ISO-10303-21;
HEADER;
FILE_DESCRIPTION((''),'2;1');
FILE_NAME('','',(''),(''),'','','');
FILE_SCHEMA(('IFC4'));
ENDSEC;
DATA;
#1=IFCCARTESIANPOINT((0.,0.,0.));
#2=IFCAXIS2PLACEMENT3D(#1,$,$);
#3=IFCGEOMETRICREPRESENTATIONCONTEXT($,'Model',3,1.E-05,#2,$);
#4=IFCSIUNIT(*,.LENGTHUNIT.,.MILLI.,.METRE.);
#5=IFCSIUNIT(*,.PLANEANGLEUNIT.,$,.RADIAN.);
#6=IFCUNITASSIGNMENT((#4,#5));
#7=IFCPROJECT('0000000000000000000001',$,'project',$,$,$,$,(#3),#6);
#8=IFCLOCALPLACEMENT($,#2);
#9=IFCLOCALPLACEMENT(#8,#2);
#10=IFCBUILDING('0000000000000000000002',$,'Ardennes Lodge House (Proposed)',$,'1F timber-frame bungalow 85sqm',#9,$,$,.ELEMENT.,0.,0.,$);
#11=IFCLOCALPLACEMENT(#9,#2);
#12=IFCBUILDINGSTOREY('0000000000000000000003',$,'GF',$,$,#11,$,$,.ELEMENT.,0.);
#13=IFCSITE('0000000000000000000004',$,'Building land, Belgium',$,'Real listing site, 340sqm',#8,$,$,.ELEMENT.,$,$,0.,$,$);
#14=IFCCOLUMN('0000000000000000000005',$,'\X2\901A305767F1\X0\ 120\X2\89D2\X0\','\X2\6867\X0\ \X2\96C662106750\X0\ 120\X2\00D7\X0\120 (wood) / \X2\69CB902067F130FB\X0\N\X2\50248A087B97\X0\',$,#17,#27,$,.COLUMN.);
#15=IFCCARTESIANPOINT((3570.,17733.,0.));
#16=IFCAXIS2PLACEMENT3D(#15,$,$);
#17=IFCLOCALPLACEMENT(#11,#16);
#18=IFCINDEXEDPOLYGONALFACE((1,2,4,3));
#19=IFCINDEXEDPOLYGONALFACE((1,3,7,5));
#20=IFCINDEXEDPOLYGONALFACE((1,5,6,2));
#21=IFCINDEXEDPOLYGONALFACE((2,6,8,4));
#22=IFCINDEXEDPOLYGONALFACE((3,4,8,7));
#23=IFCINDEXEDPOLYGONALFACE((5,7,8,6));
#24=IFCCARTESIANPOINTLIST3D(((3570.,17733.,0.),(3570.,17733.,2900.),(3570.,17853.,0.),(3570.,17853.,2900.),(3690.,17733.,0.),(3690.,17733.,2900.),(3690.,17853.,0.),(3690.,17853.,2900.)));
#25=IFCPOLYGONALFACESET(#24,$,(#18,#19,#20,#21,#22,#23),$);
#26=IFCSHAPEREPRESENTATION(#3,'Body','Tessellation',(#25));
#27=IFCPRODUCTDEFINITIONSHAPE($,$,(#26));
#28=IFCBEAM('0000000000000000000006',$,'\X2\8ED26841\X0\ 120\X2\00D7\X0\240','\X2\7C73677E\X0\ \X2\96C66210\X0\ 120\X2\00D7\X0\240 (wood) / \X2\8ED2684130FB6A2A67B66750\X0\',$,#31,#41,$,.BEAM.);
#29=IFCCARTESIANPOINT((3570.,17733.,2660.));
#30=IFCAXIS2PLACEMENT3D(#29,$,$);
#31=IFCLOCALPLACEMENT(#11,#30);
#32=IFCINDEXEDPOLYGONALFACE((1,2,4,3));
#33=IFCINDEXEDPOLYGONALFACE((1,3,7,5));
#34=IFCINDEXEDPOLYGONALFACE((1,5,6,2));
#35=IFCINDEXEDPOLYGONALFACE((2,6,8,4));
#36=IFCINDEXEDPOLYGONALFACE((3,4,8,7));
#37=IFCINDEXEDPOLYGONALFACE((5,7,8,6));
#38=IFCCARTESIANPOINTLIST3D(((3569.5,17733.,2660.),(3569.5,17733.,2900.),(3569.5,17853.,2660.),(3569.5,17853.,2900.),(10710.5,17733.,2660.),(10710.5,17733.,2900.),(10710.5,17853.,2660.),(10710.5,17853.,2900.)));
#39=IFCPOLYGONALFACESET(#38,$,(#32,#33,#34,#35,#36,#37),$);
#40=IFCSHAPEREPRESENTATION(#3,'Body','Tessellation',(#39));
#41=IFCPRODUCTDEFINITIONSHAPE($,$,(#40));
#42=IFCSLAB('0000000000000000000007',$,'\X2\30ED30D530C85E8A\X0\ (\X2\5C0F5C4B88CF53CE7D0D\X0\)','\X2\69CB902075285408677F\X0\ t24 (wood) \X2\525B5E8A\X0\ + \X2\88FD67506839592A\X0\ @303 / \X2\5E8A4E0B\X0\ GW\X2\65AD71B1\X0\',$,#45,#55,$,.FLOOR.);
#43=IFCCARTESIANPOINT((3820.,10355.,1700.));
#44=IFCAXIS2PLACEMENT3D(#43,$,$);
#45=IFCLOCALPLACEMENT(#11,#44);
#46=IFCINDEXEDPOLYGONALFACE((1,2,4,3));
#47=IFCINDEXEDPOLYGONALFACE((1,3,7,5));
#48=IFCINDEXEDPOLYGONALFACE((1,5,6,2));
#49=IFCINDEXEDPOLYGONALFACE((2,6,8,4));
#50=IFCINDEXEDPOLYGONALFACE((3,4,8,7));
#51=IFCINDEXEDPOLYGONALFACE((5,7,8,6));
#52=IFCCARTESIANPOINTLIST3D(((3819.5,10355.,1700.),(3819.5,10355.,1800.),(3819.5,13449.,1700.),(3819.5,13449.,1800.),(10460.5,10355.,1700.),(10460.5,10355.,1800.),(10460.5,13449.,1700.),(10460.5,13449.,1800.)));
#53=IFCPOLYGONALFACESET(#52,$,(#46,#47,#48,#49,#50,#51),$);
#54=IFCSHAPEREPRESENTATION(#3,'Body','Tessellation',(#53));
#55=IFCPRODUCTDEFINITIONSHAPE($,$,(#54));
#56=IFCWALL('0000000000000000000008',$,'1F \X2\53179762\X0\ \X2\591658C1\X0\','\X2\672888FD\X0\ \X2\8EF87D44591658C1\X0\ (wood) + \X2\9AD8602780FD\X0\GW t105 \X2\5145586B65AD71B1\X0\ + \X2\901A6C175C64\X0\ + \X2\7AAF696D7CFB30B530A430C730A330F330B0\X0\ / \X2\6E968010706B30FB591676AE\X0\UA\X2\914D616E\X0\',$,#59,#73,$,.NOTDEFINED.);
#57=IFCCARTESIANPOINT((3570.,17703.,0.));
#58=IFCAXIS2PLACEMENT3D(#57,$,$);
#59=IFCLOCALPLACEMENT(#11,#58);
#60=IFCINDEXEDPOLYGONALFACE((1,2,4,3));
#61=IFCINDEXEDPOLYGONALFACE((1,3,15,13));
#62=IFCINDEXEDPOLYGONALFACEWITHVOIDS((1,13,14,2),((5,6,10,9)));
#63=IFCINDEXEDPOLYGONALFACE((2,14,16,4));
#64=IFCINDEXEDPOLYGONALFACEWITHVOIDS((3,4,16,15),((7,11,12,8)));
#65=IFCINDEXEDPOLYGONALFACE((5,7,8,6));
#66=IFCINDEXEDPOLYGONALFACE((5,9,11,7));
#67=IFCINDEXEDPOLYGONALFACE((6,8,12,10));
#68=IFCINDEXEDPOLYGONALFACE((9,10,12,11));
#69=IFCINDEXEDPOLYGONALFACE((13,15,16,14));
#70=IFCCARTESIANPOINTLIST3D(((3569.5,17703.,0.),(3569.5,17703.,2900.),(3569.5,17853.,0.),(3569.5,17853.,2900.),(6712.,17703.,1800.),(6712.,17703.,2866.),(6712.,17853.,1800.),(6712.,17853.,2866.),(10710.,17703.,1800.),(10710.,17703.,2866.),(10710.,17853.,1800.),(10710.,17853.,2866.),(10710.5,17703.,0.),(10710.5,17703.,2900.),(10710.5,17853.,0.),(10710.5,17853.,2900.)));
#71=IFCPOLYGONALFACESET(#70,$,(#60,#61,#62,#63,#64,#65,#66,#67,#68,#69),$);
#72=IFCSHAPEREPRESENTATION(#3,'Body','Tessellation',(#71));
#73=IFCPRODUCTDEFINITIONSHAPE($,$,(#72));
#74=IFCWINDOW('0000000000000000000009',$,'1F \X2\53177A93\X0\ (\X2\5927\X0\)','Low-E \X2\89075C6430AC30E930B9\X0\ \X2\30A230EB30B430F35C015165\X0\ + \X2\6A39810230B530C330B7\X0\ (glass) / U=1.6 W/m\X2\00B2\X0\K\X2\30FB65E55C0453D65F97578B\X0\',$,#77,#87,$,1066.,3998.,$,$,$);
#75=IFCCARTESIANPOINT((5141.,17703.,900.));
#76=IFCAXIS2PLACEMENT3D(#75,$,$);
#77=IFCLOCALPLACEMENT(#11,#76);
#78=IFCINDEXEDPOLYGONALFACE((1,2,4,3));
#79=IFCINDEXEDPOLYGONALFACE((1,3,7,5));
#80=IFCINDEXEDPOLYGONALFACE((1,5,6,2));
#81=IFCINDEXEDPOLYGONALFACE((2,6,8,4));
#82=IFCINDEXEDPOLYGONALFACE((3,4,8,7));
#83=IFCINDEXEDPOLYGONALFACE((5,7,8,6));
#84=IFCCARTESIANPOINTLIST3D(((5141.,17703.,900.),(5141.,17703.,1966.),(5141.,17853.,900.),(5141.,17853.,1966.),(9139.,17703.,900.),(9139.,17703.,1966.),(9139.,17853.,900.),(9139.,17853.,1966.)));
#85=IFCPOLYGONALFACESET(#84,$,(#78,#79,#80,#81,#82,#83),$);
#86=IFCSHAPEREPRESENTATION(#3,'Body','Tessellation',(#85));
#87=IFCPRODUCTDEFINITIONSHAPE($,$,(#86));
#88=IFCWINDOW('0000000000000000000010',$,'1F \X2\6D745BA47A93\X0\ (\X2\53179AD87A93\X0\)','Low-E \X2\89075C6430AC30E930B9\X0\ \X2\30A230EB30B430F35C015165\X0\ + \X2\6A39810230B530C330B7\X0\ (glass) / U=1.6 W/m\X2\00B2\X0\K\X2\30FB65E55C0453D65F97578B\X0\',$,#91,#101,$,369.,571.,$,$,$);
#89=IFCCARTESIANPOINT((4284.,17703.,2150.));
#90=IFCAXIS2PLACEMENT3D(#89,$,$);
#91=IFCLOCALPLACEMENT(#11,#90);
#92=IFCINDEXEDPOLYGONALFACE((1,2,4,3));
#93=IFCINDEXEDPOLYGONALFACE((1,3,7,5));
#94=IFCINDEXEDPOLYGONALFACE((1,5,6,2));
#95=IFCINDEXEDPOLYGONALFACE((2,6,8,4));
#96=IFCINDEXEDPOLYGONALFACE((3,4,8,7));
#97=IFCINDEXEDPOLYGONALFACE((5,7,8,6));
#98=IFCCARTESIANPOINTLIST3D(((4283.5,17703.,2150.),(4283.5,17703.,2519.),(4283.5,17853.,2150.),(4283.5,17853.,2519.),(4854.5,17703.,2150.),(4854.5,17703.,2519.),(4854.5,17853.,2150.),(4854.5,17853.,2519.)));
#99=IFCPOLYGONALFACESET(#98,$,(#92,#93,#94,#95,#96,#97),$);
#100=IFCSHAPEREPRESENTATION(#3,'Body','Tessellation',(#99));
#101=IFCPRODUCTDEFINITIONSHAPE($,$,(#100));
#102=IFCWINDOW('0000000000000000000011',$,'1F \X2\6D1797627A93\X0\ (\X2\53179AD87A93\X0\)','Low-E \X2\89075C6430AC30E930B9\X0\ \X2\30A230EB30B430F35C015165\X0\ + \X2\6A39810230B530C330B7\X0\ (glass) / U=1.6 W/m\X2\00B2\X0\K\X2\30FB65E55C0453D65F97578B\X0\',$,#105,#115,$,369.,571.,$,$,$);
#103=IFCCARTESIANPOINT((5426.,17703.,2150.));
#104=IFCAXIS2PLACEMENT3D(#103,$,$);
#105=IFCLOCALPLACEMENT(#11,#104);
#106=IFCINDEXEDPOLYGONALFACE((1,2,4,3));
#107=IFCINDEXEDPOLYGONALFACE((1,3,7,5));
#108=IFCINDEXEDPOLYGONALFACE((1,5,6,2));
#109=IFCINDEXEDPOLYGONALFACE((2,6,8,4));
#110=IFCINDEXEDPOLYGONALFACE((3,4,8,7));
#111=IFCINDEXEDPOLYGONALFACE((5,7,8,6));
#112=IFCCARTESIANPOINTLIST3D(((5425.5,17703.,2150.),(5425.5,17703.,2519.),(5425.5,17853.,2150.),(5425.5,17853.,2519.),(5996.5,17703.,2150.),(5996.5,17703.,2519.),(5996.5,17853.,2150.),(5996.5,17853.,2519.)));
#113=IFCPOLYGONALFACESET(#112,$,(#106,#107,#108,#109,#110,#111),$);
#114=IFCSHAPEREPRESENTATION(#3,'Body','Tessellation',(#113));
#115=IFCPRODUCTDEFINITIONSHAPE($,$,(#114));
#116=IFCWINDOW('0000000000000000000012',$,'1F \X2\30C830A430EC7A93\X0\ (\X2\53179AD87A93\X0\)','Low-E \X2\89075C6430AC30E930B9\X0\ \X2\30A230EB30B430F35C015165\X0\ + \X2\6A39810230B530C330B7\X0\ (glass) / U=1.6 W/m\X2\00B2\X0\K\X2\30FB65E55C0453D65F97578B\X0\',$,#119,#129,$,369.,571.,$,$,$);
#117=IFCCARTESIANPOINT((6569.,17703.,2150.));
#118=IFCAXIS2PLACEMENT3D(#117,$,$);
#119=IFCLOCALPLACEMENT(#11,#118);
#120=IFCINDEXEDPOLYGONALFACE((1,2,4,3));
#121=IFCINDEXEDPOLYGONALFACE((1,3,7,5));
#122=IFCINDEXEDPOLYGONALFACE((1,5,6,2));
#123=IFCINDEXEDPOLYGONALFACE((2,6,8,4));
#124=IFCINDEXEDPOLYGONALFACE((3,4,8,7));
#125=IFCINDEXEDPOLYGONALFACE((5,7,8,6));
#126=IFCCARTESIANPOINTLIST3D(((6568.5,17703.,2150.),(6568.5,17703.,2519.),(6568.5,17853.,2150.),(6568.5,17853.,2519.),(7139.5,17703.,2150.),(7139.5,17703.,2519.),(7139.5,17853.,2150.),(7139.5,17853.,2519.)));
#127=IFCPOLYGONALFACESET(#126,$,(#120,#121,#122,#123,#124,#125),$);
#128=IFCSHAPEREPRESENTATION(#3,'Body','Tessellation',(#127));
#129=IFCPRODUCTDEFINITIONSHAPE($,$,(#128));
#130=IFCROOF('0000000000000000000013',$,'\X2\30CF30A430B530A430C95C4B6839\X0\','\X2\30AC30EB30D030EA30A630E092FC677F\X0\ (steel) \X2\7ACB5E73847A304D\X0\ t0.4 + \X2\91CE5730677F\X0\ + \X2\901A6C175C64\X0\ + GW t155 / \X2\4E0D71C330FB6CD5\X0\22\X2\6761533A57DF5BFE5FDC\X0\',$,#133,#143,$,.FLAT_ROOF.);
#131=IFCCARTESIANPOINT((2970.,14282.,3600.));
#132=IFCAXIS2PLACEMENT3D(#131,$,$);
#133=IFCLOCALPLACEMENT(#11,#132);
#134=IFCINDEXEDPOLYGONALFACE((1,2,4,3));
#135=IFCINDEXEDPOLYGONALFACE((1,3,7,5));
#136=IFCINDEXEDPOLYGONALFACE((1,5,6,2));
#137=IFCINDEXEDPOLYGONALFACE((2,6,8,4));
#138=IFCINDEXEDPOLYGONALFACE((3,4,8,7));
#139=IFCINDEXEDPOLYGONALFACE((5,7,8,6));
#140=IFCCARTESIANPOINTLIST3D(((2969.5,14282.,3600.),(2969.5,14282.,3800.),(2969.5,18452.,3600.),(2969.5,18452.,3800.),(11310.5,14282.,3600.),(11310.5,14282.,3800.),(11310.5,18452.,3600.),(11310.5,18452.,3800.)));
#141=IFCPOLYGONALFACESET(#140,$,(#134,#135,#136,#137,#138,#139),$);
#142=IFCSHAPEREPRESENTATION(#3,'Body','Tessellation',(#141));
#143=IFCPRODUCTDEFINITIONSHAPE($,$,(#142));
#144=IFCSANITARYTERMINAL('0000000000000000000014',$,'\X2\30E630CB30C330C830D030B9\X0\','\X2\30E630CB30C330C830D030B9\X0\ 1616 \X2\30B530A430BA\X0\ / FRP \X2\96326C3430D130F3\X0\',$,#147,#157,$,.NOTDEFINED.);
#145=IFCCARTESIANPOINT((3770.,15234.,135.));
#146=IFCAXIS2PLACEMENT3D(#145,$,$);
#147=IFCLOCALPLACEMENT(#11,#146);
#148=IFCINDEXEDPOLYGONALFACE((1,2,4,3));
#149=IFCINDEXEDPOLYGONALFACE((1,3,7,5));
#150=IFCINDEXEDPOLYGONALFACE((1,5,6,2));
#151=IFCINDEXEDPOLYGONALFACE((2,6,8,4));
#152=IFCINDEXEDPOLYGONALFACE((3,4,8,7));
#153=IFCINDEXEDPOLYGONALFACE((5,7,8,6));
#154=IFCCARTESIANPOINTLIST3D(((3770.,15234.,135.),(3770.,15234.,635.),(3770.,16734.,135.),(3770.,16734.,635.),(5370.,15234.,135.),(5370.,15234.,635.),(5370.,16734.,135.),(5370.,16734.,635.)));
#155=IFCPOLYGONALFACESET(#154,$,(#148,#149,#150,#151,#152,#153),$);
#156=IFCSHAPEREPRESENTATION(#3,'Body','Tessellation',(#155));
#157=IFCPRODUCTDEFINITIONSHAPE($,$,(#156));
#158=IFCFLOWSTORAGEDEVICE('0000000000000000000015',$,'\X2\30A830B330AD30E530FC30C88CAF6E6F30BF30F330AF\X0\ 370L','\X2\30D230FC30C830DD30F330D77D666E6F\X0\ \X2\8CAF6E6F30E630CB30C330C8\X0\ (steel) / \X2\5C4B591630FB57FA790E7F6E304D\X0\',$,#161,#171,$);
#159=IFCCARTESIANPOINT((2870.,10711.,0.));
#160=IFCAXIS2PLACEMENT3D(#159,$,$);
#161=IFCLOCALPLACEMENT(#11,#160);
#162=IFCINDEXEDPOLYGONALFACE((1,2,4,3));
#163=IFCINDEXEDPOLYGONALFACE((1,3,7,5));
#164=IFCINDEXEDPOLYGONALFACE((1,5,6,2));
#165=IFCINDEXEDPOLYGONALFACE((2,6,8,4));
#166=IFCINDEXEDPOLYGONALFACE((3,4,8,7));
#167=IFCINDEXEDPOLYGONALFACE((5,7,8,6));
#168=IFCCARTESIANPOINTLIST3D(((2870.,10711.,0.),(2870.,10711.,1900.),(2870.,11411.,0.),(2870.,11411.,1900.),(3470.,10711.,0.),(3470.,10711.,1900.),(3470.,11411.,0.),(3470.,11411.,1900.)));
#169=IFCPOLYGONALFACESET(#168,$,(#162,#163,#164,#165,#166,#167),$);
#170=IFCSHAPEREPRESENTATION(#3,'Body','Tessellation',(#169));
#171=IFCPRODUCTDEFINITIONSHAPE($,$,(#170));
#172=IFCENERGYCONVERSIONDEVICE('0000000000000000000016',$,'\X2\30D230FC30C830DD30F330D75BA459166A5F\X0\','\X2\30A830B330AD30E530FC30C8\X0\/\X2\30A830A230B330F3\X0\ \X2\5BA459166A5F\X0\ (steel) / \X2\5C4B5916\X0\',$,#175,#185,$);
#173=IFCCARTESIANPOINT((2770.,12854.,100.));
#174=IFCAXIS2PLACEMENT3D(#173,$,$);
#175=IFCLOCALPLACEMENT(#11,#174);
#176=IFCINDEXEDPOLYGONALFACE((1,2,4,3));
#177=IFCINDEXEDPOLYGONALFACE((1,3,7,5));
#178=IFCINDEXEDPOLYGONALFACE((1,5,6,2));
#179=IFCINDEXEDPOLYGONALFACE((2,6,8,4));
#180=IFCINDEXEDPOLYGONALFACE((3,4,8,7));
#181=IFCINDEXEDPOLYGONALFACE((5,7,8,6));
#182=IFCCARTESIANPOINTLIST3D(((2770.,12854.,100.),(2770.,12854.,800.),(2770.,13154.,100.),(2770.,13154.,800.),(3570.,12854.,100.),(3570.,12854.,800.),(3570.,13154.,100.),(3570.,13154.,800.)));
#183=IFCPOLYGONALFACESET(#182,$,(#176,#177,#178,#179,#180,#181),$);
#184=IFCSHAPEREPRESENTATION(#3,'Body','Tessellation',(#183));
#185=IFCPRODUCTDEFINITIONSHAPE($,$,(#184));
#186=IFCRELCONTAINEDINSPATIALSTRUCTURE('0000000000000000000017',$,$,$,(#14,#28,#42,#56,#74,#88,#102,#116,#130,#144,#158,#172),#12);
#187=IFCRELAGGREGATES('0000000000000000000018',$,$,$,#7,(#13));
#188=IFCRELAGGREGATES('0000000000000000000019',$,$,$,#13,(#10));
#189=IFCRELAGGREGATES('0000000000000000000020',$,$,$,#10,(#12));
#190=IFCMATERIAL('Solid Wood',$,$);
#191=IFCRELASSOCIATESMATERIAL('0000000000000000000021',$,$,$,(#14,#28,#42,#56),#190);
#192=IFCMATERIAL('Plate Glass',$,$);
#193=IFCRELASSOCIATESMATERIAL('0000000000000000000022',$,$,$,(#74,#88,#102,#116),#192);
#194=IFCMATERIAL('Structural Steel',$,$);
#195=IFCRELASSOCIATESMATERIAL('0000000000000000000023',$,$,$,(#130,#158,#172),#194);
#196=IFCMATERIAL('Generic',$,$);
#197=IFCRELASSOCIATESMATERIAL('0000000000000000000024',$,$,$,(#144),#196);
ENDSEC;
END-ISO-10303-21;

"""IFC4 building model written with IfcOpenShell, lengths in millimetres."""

from ifc_helpers import new_model, si_unit, frame, frame_2d, origin, place, context, project, spatial, rectangle, extrude, material, element, fill, save


model = new_model("IFC4")

# Units and contexts
model_context = context("Model", 3, precision=1e-05, world=origin())
ifc_project = project(units=[si_unit("LENGTHUNIT", "METRE", prefix="MILLI"), si_unit("PLANEANGLEUNIT", "RADIAN")], contexts=[model_context])

# Site, building, storey
site_placement = place(None, origin())
site = spatial("IfcSite", under=ifc_project, at=site_placement, Name="Building land, Belgium", ObjectType="Real listing site, 340sqm", CompositionType="ELEMENT", RefElevation=0.0)
building_placement = place(site_placement, origin())
building = spatial("IfcBuilding", under=site, at=building_placement, Name="Ardennes Lodge House (Proposed)", ObjectType="1F timber-frame bungalow 85sqm", CompositionType="ELEMENT", ElevationOfRefHeight=0.0, ElevationOfTerrain=0.0)
storey_placement = place(building_placement, origin())
storey = spatial("IfcBuildingStorey", under=building, at=storey_placement, Name="GF", CompositionType="ELEMENT", Elevation=0.0)

# Column
ifc_material_1 = material(Name="Solid Wood")
column_1_placement = place(storey_placement, frame((3570.0, 17733.0, 0.0)))
element("IfcColumn", 1, at=column_1_placement, inside=storey, material=ifc_material_1, Name="通し柱 120角", Description="桧 集成材 120×120 (wood) / 構造柱・N値計算", PredefinedType="COLUMN", context=model_context, shape_type="SweptSolid", body=[
    extrude(rectangle(XDim=120.0, YDim=120.0, at=frame_2d((60.0, 60.0))), frame((3570.0, 17733.0, 0.0)), (0.0, 0.0, 1.0), 2900.0),
])

# Beam
beam_1_placement = place(storey_placement, frame((3570.0, 17733.0, 2660.0)))
element("IfcBeam", 2, at=beam_1_placement, inside=storey, material=ifc_material_1, Name="軒桁 120×240", Description="米松 集成 120×240 (wood) / 軒桁・横架材", PredefinedType="BEAM", context=model_context, shape_type="SweptSolid", body=[
    extrude(rectangle(XDim=7141.0, YDim=120.0, at=frame_2d((3570.0, 60.0))), frame((3570.0, 17733.0, 2660.0)), (0.0, 0.0, 1.0), 240.0),
])

# Slab
slab_placement = place(storey_placement, frame((3820.0, 10355.0, 1700.0)))
element("IfcSlab", 3, at=slab_placement, inside=storey, material=ifc_material_1, Name="ロフト床 (小屋裏収納)", Description="構造用合板 t24 (wood) 剛床 + 製材根太 @303 / 床下 GW断熱", PredefinedType="FLOOR", context=model_context, shape_type="SweptSolid", body=[
    extrude(rectangle(XDim=6641.0, YDim=3094.0, at=frame_2d((3320.0, 1547.0))), frame((3820.0, 10355.0, 1700.0)), (0.0, 0.0, 1.0), 100.0),
])

# Wall, openings, windows
wall_1_placement = place(storey_placement, frame((3570.0, 17703.0, 0.0)))
wall_1 = element("IfcWall", 4, at=wall_1_placement, inside=storey, material=ifc_material_1, Name="1F 北面 外壁", Description="木製 軸組外壁 (wood) + 高性能GW t105 充填断熱 + 通気層 + 窯業系サイディング / 準耐火・外皮UA配慮", PredefinedType="NOTDEFINED", context=model_context, shape_type="SweptSolid", body=[
    extrude(rectangle(XDim=7141.0, YDim=150.0, at=frame_2d((3570.0, 75.0))), frame((3570.0, 17703.0, 0.0)), (0.0, 0.0, 1.0), 2900.0),
])
opening_1_placement = place(storey_placement, frame((5141.0, 17703.0, 900.0)))
opening_1 = element("IfcOpeningElement", 5, at=opening_1_placement, cuts=wall_1, PredefinedType="NOTDEFINED", context=model_context, shape_type="SweptSolid", body=[
    extrude(rectangle(XDim=3998.0, YDim=150.0, at=frame_2d((1999.0, 75.0))), frame((5141.0, 17703.0, 900.0)), (0.0, 0.0, 1.0), 1066.0),
])
opening_2_placement = place(storey_placement, frame((4284.0, 17703.0, 2150.0)))
opening_2 = element("IfcOpeningElement", 6, at=opening_2_placement, cuts=wall_1, PredefinedType="NOTDEFINED", context=model_context, shape_type="SweptSolid", body=[
    extrude(rectangle(XDim=571.0, YDim=150.0, at=frame_2d((285.0, 75.0))), frame((4284.0, 17703.0, 2150.0)), (0.0, 0.0, 1.0), 369.0),
])
opening_3_placement = place(storey_placement, frame((5426.0, 17703.0, 2150.0)))
opening_3 = element("IfcOpeningElement", 7, at=opening_3_placement, cuts=wall_1, PredefinedType="NOTDEFINED", context=model_context, shape_type="SweptSolid", body=[
    extrude(rectangle(XDim=571.0, YDim=150.0, at=frame_2d((285.0, 75.0))), frame((5426.0, 17703.0, 2150.0)), (0.0, 0.0, 1.0), 369.0),
])
opening_4_placement = place(storey_placement, frame((6569.0, 17703.0, 2150.0)))
opening_4 = element("IfcOpeningElement", 8, at=opening_4_placement, cuts=wall_1, PredefinedType="NOTDEFINED", context=model_context, shape_type="SweptSolid", body=[
    extrude(rectangle(XDim=571.0, YDim=150.0, at=frame_2d((285.0, 75.0))), frame((6569.0, 17703.0, 2150.0)), (0.0, 0.0, 1.0), 369.0),
])
ifc_material_2 = material(Name="Plate Glass")
window_1_placement = place(storey_placement, frame((5141.0, 17703.0, 900.0)))
window_1 = element("IfcWindow", 9, at=window_1_placement, inside=storey, material=ifc_material_2, Name="1F 北窓 (大)", Description="Low-E 複層ガラス アルゴン封入 + 樹脂サッシ (glass) / U=1.6 W/m²K・日射取得型", OverallHeight=1066.0, OverallWidth=3998.0, context=model_context, shape_type="SweptSolid", body=[
    extrude(rectangle(XDim=3998.0, YDim=150.0, at=frame_2d((1999.0, 75.0))), frame((5141.0, 17703.0, 900.0)), (0.0, 0.0, 1.0), 1066.0),
])
fill(opening_1, window_1)
window_2_placement = place(storey_placement, frame((4284.0, 17703.0, 2150.0)))
window_2 = element("IfcWindow", 10, at=window_2_placement, inside=storey, material=ifc_material_2, Name="1F 浴室窓 (北高窓)", Description="Low-E 複層ガラス アルゴン封入 + 樹脂サッシ (glass) / U=1.6 W/m²K・日射取得型", OverallHeight=369.0, OverallWidth=571.0, context=model_context, shape_type="SweptSolid", body=[
    extrude(rectangle(XDim=571.0, YDim=150.0, at=frame_2d((285.0, 75.0))), frame((4284.0, 17703.0, 2150.0)), (0.0, 0.0, 1.0), 369.0),
])
fill(opening_2, window_2)
window_3_placement = place(storey_placement, frame((5426.0, 17703.0, 2150.0)))
window_3 = element("IfcWindow", 11, at=window_3_placement, inside=storey, material=ifc_material_2, Name="1F 洗面窓 (北高窓)", Description="Low-E 複層ガラス アルゴン封入 + 樹脂サッシ (glass) / U=1.6 W/m²K・日射取得型", OverallHeight=369.0, OverallWidth=571.0, context=model_context, shape_type="SweptSolid", body=[
    extrude(rectangle(XDim=571.0, YDim=150.0, at=frame_2d((285.0, 75.0))), frame((5426.0, 17703.0, 2150.0)), (0.0, 0.0, 1.0), 369.0),
])
fill(opening_3, window_3)
window_4_placement = place(storey_placement, frame((6569.0, 17703.0, 2150.0)))
window_4 = element("IfcWindow", 12, at=window_4_placement, inside=storey, material=ifc_material_2, Name="1F トイレ窓 (北高窓)", Description="Low-E 複層ガラス アルゴン封入 + 樹脂サッシ (glass) / U=1.6 W/m²K・日射取得型", OverallHeight=369.0, OverallWidth=571.0, context=model_context, shape_type="SweptSolid", body=[
    extrude(rectangle(XDim=571.0, YDim=150.0, at=frame_2d((285.0, 75.0))), frame((6569.0, 17703.0, 2150.0)), (0.0, 0.0, 1.0), 369.0),
])
fill(opening_4, window_4)

# Roof
ifc_material_3 = material(Name="Structural Steel")
roof_placement = place(storey_placement, frame((2970.0, 14282.0, 3600.0)))
element("IfcRoof", 13, at=roof_placement, inside=storey, material=ifc_material_3, Name="ハイサイド屋根", Description="ガルバリウム鋼板 (steel) 立平葺き t0.4 + 野地板 + 通気層 + GW t155 / 不燃・法22条区域対応", PredefinedType="FLAT_ROOF", context=model_context, shape_type="SweptSolid", body=[
    extrude(rectangle(XDim=8341.0, YDim=4170.0, at=frame_2d((4170.0, 2085.0))), frame((2970.0, 14282.0, 3600.0)), (0.0, 0.0, 1.0), 200.0),
])

# Sanitary terminal
ifc_material_4 = material(Name="Generic")
sanitary_terminal_placement = place(storey_placement, frame((3770.0, 15234.0, 135.0)))
element("IfcSanitaryTerminal", 14, at=sanitary_terminal_placement, inside=storey, material=ifc_material_4, Name="ユニットバス", Description="ユニットバス 1616 サイズ / FRP 防水パン", PredefinedType="NOTDEFINED", context=model_context, shape_type="SweptSolid", body=[
    extrude(rectangle(XDim=1600.0, YDim=1500.0, at=frame_2d((800.0, 750.0))), frame((3770.0, 15234.0, 135.0)), (0.0, 0.0, 1.0), 500.0),
])

# Flow storage device
flow_storage_device_placement = place(storey_placement, frame((2870.0, 10711.0, 0.0)))
element("IfcFlowStorageDevice", 15, at=flow_storage_device_placement, inside=storey, material=ifc_material_3, Name="エコキュート貯湯タンク 370L", Description="ヒートポンプ給湯 貯湯ユニット (steel) / 屋外・基礎置き", context=model_context, shape_type="SweptSolid", body=[
    extrude(rectangle(XDim=600.0, YDim=700.0, at=frame_2d((300.0, 350.0))), frame((2870.0, 10711.0, 0.0)), (0.0, 0.0, 1.0), 1900.0),
])

# Energy conversion device
energy_conversion_device_placement = place(storey_placement, frame((2770.0, 12854.0, 100.0)))
element("IfcEnergyConversionDevice", 16, at=energy_conversion_device_placement, inside=storey, material=ifc_material_3, Name="ヒートポンプ室外機", Description="エコキュート/エアコン 室外機 (steel) / 屋外", context=model_context, shape_type="SweptSolid", body=[
    extrude(rectangle(XDim=800.0, YDim=300.0, at=frame_2d((400.0, 150.0))), frame((2770.0, 12854.0, 100.0)), (0.0, 0.0, 1.0), 700.0),
])

save(model, "model.ifc")
